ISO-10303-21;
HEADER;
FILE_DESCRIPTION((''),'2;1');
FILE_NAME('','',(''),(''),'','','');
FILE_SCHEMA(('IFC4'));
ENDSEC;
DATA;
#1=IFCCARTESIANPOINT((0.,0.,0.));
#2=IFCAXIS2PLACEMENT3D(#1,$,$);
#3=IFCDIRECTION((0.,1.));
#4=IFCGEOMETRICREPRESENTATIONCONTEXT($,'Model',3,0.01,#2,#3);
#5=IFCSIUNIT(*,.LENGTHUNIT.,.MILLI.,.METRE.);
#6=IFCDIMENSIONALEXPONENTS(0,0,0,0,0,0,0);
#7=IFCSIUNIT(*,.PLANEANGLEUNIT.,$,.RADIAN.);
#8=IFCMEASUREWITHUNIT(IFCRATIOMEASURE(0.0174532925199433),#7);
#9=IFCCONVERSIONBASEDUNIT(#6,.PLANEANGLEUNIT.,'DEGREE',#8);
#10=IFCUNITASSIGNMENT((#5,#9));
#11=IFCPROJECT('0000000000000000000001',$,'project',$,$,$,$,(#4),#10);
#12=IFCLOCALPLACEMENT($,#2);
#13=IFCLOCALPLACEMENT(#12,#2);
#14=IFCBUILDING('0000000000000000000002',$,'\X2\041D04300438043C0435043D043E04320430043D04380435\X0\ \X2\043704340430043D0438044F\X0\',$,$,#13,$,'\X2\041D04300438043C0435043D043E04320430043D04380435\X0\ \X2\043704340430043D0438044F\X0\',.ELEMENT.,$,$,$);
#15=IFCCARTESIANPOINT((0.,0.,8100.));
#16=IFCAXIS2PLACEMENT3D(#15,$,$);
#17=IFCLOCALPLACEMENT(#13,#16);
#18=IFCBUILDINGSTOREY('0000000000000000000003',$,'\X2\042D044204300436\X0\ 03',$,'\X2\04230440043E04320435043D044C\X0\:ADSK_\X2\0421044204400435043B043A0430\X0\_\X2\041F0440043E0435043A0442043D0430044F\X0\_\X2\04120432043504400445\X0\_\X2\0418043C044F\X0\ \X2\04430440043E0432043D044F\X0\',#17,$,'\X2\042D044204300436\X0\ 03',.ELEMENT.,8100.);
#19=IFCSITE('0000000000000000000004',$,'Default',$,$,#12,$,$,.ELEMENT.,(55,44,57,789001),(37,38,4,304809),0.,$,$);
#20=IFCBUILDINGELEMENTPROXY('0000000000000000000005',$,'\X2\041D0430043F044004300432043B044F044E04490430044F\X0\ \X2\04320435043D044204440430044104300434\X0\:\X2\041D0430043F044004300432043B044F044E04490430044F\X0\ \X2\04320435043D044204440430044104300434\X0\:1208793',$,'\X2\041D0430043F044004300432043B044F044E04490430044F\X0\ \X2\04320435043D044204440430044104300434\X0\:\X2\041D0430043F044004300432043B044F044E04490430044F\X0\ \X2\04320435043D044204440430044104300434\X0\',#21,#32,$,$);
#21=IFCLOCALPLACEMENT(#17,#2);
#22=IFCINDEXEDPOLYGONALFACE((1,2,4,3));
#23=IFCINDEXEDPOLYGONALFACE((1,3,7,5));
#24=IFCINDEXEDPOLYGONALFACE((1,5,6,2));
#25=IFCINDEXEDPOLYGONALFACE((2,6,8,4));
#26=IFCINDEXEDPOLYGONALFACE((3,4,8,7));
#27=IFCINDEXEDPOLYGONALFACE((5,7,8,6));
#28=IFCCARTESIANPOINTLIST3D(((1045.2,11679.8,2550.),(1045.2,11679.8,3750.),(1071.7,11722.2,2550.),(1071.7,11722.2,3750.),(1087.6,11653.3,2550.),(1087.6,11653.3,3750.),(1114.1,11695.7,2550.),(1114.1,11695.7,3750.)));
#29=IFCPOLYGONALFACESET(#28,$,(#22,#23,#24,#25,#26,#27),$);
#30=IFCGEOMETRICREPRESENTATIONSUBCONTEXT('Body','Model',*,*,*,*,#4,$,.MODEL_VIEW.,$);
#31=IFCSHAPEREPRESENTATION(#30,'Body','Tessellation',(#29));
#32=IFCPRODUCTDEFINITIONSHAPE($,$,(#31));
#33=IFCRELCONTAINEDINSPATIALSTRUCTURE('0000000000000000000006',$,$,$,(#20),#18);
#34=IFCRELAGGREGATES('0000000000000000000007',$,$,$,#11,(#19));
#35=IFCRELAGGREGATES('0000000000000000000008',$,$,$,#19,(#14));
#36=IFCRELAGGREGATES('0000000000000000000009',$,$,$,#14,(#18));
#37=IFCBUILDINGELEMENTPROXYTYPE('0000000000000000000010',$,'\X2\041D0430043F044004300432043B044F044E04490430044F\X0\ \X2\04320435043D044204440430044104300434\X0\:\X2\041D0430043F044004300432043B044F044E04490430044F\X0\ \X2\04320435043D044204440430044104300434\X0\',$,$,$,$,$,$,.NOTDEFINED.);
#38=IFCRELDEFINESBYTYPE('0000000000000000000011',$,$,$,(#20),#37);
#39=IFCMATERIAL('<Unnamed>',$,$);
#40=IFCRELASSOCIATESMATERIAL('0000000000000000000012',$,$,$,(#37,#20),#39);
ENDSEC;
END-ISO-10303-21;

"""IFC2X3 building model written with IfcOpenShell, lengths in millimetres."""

from ifc_helpers import new_model, entity, si_unit, converted_unit, direction, frame, origin, origin_2d_with_axis, place, context, subcontext, project, spatial, rectangle, extrude, source, transform, mapped, material, type_object, type_shapes, element, save


model = new_model("IFC2X3")

# Units and contexts
model_context = context("Model", 3, precision=0.01, world=origin(), true_north=direction((0.0, 1.0)))
body_context = subcontext(model_context, "Body", "Model", "MODEL_VIEW")
ifc_project = project(units=[si_unit("LENGTHUNIT", "METRE", prefix="MILLI"), converted_unit("PLANEANGLEUNIT", "DEGREE", entity("IfcRatioMeasure", 0.0174532925199433), si_unit("PLANEANGLEUNIT", "RADIAN"), dimensions=[0, 0, 0, 0, 0, 0, 0])], contexts=[model_context])

# Site, building, storey
site_placement = place(None, origin())
site = spatial("IfcSite", under=ifc_project, at=site_placement, Name="Default", CompositionType="ELEMENT", RefLatitude=(55, 44, 57, 789001), RefLongitude=(37, 38, 4, 304809), RefElevation=0.0)
building_placement = place(site_placement, origin())
building = spatial("IfcBuilding", under=site, at=building_placement, Name="Наименование здания", LongName="Наименование здания", CompositionType="ELEMENT")
storey_placement = place(building_placement, frame((0.0, 0.0, 8100.0)))
storey = spatial("IfcBuildingStorey", under=building, at=storey_placement, Name="Этаж 03", ObjectType="Уровень:ADSK_Стрелка_Проектная_Вверх_Имя уровня", LongName="Этаж 03", CompositionType="ELEMENT", Elevation=8100.0)

# Building element proxy
ifc_material_1 = material(Name="<Unnamed>")
building_element_proxy_type_1 = type_object("IfcBuildingElementProxyType", Name="Направляющая вентфасад:Направляющая вентфасад", PredefinedType="NOTDEFINED", material=ifc_material_1)
shared_shape_1 = source(origin(), body_context, "Body", "SweptSolid", [
    extrude(rectangle(XDim=50.0, YDim=50.0, at=origin_2d_with_axis()), frame((25.0, -25.0, 0.0), z_axis=(0.0, 0.0, 1.0), x_axis=(-1.0, 0.0, 0.0)), (0.0, 0.0, 1.0), 1200.0),
])
type_shapes(building_element_proxy_type_1, [shared_shape_1])
proxy_1_placement = place(storey_placement, frame((1071.7, 11722.2, 2550.0), z_axis=(0.0, 0.0, 1.0), x_axis=(0.848053, -0.529912, 0.0)))
element("IfcBuildingElementProxy", 1, at=proxy_1_placement, inside=storey, type_object=building_element_proxy_type_1, material=ifc_material_1, Name="Направляющая вентфасад:Направляющая вентфасад:1208793", ObjectType="Направляющая вентфасад:Направляющая вентфасад", context=body_context, shape_type="MappedRepresentation", body=[
    mapped(shared_shape_1, transform((0.0, 0.0, 0.0), scale=1.0)),
])

save(model, "model.ifc")
